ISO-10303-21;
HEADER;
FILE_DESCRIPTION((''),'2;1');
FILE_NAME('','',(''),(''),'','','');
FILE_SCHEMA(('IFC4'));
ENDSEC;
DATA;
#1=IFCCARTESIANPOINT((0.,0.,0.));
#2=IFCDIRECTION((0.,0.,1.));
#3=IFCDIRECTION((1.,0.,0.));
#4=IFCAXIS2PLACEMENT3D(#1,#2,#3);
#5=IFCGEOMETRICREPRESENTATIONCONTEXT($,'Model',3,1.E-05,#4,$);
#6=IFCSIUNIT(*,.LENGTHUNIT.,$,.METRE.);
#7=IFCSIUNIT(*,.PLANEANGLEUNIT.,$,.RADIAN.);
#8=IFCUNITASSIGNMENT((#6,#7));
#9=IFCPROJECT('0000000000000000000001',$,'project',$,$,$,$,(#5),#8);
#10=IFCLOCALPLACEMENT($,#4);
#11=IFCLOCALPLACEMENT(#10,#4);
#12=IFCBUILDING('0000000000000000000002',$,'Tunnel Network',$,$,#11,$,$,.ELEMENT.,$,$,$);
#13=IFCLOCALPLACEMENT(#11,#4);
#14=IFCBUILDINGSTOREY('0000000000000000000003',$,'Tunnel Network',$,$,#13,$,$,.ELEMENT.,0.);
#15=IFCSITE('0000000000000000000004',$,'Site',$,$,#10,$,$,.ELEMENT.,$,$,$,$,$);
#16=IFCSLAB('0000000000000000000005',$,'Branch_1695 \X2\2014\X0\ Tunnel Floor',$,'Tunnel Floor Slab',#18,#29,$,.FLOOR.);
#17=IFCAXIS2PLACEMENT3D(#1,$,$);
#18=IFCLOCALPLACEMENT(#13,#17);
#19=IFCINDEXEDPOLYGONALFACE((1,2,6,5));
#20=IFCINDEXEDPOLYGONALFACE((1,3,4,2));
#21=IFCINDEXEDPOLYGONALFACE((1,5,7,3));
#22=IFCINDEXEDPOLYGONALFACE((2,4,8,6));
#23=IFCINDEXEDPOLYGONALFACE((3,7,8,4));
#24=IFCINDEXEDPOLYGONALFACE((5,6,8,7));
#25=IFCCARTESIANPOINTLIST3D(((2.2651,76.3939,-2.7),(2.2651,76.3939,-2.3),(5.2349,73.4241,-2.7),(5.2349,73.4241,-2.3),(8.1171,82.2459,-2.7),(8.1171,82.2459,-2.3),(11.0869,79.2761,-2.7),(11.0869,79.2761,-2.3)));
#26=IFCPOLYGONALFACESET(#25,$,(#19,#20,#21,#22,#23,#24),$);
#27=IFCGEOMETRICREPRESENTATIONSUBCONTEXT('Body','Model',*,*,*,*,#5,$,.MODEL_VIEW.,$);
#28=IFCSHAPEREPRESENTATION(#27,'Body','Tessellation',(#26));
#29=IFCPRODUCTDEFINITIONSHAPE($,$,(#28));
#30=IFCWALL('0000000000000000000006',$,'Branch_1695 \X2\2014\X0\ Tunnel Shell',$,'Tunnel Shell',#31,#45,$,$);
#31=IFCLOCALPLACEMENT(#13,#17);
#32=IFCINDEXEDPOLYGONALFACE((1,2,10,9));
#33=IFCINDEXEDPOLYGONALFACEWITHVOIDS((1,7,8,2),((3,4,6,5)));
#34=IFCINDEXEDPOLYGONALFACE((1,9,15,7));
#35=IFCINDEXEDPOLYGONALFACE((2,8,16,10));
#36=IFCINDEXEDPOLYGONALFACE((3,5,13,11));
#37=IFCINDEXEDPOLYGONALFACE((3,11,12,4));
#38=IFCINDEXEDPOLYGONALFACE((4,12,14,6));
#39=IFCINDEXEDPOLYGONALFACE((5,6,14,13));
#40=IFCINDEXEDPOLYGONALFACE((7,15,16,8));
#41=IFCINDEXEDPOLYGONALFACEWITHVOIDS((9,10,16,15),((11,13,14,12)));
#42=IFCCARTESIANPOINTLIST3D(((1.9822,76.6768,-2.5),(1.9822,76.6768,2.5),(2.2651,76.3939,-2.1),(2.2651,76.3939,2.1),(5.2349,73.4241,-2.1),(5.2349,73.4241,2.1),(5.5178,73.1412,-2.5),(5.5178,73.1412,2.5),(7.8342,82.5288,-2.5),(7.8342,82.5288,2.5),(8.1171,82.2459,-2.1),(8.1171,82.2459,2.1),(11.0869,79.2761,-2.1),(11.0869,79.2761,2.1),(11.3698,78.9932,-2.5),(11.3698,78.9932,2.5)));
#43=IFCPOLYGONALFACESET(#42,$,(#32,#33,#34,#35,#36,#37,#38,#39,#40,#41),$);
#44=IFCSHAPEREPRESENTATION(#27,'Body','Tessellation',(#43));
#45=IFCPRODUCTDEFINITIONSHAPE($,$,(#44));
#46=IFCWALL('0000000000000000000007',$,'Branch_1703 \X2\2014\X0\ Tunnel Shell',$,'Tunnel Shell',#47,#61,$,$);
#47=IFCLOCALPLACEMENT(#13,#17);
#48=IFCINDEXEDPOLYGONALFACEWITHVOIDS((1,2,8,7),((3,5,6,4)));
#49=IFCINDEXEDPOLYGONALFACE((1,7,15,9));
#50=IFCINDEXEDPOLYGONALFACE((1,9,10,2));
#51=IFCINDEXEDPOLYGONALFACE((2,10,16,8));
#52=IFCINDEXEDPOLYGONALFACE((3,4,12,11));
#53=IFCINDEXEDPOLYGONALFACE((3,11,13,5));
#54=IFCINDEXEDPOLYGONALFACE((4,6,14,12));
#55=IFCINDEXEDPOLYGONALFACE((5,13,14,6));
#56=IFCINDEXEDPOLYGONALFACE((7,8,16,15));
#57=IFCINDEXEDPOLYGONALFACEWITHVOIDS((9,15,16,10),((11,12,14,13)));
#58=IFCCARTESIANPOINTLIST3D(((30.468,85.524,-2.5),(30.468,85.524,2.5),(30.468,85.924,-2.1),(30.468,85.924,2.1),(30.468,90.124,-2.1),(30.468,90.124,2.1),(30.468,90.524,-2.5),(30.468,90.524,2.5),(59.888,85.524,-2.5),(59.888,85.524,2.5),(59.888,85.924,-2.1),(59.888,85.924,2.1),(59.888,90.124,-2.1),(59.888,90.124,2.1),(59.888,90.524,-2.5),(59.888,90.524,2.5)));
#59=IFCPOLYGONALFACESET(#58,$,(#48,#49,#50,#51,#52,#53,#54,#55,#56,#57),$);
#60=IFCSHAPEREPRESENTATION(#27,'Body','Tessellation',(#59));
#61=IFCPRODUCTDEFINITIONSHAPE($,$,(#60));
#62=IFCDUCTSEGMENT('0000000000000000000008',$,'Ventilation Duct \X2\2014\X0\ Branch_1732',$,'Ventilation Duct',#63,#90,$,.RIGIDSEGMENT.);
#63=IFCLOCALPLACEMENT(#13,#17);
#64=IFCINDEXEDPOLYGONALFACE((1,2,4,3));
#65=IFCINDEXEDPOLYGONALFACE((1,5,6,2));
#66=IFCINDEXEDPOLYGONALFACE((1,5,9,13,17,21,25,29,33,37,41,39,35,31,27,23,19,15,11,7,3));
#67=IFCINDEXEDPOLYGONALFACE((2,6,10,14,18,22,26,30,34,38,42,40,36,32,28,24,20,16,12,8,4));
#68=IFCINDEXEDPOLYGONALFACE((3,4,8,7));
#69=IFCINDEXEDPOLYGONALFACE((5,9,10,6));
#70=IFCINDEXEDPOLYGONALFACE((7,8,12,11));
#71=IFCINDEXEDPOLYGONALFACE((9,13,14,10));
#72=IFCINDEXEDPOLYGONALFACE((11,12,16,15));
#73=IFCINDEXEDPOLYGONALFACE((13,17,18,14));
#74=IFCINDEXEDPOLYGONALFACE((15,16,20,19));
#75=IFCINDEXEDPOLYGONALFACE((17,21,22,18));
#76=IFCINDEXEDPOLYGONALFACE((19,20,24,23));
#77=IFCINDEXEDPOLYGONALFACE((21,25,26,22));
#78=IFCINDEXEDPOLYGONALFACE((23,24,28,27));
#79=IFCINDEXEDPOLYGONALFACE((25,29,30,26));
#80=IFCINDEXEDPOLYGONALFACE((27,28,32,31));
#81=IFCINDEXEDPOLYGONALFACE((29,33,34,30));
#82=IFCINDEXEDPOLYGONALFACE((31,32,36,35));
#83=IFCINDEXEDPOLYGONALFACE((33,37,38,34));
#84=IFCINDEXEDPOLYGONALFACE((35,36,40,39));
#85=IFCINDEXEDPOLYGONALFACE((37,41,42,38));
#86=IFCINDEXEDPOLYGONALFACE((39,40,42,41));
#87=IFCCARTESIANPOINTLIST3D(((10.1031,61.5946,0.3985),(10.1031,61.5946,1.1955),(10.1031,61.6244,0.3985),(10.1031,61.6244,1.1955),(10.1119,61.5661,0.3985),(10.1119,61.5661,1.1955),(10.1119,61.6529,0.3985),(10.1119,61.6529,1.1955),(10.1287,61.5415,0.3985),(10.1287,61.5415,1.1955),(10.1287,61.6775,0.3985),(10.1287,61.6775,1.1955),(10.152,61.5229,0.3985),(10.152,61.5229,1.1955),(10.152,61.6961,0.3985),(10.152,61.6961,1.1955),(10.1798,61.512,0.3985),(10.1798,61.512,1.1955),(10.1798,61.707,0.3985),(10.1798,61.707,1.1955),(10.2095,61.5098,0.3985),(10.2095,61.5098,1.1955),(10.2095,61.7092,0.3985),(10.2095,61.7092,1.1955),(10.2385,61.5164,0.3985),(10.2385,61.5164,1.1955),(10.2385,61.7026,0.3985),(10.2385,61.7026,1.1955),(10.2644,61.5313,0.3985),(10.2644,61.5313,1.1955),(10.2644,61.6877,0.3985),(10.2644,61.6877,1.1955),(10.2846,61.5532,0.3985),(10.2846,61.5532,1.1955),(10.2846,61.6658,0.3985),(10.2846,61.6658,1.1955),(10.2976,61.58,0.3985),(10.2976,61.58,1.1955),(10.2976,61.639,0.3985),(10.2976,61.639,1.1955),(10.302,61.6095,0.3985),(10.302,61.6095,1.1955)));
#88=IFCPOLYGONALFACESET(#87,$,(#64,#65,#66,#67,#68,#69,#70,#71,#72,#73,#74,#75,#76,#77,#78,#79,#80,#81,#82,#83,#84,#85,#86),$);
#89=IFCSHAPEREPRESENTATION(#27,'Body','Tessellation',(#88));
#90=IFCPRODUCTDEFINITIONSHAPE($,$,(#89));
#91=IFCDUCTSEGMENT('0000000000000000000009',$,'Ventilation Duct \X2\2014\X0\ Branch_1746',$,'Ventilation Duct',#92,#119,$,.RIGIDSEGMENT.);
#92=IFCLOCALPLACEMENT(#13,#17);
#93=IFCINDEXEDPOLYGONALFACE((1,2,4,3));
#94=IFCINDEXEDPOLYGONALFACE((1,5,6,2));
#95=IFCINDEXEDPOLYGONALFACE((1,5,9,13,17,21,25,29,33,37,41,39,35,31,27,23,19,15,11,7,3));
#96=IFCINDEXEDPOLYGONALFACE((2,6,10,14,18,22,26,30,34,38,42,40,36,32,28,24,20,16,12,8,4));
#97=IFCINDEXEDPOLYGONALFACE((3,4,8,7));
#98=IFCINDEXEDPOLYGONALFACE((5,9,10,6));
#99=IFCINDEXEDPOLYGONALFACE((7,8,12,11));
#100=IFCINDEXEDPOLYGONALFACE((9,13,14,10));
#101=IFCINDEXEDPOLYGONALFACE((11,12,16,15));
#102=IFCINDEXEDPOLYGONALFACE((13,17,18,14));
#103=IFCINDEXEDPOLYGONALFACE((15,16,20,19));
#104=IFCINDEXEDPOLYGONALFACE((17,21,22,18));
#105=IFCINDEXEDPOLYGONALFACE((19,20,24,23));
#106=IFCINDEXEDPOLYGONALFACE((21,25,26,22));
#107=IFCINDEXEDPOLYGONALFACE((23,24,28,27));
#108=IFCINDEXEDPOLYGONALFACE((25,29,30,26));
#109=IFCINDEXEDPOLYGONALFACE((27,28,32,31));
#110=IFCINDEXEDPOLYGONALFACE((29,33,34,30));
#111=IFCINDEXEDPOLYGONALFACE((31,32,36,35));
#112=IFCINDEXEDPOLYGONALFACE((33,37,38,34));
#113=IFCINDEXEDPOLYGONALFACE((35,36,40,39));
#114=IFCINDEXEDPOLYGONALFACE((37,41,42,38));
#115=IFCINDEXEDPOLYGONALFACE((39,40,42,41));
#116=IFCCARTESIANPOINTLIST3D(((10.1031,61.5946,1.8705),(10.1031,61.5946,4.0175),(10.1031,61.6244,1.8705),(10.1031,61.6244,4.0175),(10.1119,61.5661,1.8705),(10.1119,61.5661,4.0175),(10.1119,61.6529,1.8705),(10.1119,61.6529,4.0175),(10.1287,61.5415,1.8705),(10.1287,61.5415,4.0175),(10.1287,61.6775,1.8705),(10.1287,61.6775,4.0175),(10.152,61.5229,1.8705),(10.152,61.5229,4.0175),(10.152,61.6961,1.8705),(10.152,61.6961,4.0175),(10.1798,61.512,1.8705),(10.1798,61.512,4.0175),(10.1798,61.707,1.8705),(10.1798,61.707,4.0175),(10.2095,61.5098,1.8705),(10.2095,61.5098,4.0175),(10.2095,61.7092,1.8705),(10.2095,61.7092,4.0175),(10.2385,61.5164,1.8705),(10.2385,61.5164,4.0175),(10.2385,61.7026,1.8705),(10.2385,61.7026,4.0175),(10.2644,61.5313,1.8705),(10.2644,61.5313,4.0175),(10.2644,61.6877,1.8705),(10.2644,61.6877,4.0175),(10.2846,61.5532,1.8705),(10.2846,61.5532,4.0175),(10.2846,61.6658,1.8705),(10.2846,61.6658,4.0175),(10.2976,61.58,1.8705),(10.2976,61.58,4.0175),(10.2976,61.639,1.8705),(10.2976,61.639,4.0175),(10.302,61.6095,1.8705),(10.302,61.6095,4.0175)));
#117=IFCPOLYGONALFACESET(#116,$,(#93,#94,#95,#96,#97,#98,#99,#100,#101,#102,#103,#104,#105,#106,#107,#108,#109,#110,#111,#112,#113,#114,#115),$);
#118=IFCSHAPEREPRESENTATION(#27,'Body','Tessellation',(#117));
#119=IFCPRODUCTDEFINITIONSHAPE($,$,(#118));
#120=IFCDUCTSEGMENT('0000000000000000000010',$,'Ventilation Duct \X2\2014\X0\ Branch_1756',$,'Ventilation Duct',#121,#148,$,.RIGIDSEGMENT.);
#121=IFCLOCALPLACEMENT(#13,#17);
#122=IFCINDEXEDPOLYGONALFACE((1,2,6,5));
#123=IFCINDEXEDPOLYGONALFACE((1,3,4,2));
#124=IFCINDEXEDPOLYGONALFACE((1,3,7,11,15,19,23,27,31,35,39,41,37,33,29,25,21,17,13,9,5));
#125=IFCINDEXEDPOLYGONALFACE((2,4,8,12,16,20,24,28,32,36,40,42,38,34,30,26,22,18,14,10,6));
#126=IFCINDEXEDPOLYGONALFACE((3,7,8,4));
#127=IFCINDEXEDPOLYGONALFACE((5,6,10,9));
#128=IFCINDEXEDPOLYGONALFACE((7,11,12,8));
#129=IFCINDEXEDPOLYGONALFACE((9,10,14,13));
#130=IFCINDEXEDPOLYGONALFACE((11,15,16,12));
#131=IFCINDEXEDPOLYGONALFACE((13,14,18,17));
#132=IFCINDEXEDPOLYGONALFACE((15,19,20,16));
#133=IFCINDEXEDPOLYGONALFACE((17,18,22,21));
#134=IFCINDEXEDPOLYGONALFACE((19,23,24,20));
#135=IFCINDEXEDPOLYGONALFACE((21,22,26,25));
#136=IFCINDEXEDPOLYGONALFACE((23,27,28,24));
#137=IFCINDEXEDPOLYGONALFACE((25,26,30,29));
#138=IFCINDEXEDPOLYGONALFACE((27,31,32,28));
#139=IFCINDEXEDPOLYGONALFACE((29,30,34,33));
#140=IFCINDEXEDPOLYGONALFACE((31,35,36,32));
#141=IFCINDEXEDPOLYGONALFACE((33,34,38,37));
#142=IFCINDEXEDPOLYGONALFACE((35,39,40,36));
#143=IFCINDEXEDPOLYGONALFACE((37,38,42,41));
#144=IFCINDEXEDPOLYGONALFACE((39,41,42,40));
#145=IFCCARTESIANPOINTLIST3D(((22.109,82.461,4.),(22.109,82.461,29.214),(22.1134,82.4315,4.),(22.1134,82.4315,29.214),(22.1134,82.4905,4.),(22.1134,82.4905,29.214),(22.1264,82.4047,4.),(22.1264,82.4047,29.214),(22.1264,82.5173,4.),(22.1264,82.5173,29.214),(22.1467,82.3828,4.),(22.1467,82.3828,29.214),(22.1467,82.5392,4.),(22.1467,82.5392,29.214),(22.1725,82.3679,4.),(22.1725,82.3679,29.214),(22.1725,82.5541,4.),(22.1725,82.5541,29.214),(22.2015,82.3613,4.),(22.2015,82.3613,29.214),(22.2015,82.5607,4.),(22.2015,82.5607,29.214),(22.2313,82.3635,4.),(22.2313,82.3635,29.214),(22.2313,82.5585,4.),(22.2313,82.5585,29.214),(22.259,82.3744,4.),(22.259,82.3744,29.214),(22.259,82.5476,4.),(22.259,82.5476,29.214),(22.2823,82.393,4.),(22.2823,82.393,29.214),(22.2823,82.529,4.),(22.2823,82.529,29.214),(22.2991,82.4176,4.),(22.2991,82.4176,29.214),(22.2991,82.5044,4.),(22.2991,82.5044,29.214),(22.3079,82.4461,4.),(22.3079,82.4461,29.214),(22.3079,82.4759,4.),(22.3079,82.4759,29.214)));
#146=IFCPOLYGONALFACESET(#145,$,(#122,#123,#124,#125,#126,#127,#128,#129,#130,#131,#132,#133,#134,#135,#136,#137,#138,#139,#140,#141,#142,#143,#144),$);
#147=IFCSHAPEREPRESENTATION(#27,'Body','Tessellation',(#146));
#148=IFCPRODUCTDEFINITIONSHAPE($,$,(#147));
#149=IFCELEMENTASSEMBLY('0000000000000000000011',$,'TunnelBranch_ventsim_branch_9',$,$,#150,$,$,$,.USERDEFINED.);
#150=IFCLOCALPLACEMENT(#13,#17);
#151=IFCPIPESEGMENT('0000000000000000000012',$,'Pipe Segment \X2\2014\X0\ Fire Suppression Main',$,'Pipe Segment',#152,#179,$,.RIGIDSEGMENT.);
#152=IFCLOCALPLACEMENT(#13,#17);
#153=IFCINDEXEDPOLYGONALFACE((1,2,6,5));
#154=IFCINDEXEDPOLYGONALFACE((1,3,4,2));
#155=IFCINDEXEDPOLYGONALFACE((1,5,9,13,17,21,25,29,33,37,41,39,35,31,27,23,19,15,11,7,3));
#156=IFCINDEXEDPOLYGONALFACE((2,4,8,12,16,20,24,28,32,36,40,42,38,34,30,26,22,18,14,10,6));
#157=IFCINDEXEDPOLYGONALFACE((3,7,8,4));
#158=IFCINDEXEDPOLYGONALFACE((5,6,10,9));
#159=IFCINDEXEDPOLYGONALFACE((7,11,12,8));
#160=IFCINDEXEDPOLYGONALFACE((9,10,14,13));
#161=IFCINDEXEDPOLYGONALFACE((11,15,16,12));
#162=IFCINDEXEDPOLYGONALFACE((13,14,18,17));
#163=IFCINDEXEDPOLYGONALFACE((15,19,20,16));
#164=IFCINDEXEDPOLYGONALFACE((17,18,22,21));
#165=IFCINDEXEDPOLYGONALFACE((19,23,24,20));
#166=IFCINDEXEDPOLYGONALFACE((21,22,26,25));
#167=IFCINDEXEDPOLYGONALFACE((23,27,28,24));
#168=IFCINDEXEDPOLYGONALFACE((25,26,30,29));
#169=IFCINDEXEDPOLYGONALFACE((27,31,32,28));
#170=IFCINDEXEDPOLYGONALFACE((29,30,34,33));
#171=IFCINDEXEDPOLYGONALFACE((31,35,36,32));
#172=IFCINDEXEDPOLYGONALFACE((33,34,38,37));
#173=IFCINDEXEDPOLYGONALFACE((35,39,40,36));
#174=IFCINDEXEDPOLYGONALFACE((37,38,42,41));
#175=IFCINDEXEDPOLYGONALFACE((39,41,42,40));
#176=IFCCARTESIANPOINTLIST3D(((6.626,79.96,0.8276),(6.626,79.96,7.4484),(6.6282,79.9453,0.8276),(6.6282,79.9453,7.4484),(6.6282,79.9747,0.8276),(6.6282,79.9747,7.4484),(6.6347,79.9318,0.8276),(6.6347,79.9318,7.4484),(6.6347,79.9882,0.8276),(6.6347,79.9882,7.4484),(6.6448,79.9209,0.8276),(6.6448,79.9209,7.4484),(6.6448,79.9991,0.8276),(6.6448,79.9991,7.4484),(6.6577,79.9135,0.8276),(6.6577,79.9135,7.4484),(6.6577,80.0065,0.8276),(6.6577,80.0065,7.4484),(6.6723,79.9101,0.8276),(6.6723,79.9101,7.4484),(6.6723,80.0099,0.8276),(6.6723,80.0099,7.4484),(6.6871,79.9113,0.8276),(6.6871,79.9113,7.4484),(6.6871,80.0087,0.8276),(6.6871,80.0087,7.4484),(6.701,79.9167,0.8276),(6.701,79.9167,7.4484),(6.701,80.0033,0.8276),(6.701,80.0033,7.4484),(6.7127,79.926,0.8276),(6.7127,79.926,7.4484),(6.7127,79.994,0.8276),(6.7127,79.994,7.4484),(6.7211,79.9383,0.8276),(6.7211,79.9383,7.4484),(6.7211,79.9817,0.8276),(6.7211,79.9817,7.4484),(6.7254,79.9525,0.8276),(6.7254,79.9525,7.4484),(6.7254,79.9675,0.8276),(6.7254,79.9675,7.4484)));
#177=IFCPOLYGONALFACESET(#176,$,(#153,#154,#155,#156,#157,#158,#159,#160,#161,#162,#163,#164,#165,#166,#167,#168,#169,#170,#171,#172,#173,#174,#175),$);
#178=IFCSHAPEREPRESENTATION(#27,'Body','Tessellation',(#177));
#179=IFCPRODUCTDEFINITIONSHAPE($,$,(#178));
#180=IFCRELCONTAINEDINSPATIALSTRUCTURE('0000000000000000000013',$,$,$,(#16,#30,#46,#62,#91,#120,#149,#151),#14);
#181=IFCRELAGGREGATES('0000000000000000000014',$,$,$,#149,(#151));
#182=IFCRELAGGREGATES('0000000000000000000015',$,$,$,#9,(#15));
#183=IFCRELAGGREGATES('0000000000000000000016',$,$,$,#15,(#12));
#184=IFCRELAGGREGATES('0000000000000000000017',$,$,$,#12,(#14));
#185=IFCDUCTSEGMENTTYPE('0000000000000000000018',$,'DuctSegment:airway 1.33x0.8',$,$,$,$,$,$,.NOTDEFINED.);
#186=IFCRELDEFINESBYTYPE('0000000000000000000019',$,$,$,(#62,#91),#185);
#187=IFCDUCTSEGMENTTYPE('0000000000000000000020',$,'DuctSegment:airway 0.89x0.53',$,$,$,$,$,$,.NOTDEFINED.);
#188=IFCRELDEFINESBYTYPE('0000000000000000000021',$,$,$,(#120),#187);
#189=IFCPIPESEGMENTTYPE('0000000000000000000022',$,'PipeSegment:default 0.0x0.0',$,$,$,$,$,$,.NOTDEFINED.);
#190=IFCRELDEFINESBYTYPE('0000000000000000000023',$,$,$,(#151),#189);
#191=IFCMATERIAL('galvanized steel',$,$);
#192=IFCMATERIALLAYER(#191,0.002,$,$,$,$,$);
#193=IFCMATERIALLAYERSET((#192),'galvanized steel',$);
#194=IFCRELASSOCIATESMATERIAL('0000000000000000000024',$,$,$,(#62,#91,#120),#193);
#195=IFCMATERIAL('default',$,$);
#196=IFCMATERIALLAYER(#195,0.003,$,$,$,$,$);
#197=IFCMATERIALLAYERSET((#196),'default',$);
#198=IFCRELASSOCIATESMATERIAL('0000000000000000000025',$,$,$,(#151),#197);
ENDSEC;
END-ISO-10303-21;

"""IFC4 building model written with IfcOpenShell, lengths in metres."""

from ifc_helpers import new_model, entity, si_unit, frame, origin_with_axes, origin_2d_with_axis, place, context, subcontext, project, spatial, rectangle, hollow_rectangle, circle, extrude, material, layer, layer_set, layer_usage, type_object, element, aggregate, save


model = new_model("IFC4")

# Units and contexts
model_context = context("Model", 3, precision=1e-05, world=origin_with_axes())
body_context = subcontext(model_context, "Body", "Model", "MODEL_VIEW")
ifc_project = project(units=[si_unit("LENGTHUNIT", "METRE"), si_unit("PLANEANGLEUNIT", "RADIAN")], contexts=[model_context])

# Site, building, storey
site_placement = place(None, origin_with_axes())
site = spatial("IfcSite", under=ifc_project, at=site_placement, Name="Site", CompositionType="ELEMENT")
building_placement = place(site_placement, origin_with_axes())
building = spatial("IfcBuilding", under=site, at=building_placement, Name="Tunnel Network", CompositionType="ELEMENT")
storey_placement = place(building_placement, origin_with_axes())
storey = spatial("IfcBuildingStorey", under=building, at=storey_placement, Name="Tunnel Network", CompositionType="ELEMENT", Elevation=0.0)

# Slab
placement = place(storey_placement, frame((9.602, 80.761, 0.0), z_axis=(0.0, 0.0, 1.0), x_axis=(-0.707107, -0.707106, 0.0)))
element("IfcSlab", 1, at=placement, inside=storey, Name="Branch_1695 — Tunnel Floor", ObjectType="Tunnel Floor Slab", PredefinedType="FLOOR", context=body_context, shape_type="SweptSolid", body=[
    extrude(rectangle(XDim=0.4, YDim=4.2, at=origin_2d_with_axis()), frame((0.0, 0.0, -2.5), z_axis=(1.0, 0.0, 0.0), x_axis=(0.0, 0.0, 1.0)), (0.0, 0.0, 1.0), 8.276),
])

# Walls
element("IfcWall", 2, at=placement, inside=storey, Name="Branch_1695 — Tunnel Shell", ObjectType="Tunnel Shell", context=body_context, shape_type="SweptSolid", body=[
    extrude(hollow_rectangle(XDim=5.0, YDim=5.0, WallThickness=0.4, at=origin_2d_with_axis()), frame((0.0, 0.0, 0.0), z_axis=(1.0, 0.0, 0.0), x_axis=(0.0, 0.0, 1.0)), (0.0, 0.0, 1.0), 8.276),
])
wall_1_placement = place(storey_placement, frame((30.468, 88.024, 0.0), z_axis=(0.0, 0.0, 1.0), x_axis=(1.0, 0.0, 0.0)))
element("IfcWall", 3, at=wall_1_placement, inside=storey, Name="Branch_1703 — Tunnel Shell", ObjectType="Tunnel Shell", context=body_context, shape_type="SweptSolid", body=[
    extrude(hollow_rectangle(XDim=5.0, YDim=5.0, WallThickness=0.4, at=origin_2d_with_axis()), frame((0.0, 0.0, 0.0), z_axis=(1.0, 0.0, 0.0), x_axis=(0.0, 0.0, 1.0)), (0.0, 0.0, 1.0), 29.42),
])

# Duct segments
ifc_material_1 = material(Name="galvanized steel")
ifc_layer_1 = layer(ifc_material_1, 0.002)
ifc_layer_set_1 = layer_set([ifc_layer_1], Name="galvanized steel")
ifc_layer_usage_1 = layer_usage(ifc_layer_set_1, "AXIS2", "POSITIVE", 0.0)
duct_segment_type_1 = type_object("IfcDuctSegmentType", Name="DuctSegment:airway 1.33x0.8")
duct_segment_1_placement = place(storey_placement, frame((10.202, 61.6095, 0.3985), z_axis=(0.0, 0.0, 1.0), x_axis=(1.0, 0.0, 0.0)))
element("IfcDuctSegment", 4, at=duct_segment_1_placement, inside=storey, type_object=duct_segment_type_1, material=ifc_layer_usage_1, Name="Ventilation Duct — Branch_1732", ObjectType="Ventilation Duct", PredefinedType="RIGIDSEGMENT", context=body_context, shape_type="AdvancedSweptSolid", body=[
    entity("IfcSweptDiskSolid", entity("IfcPolyline", [entity("IfcCartesianPoint", [0.0, 0.0, 0.0]), entity("IfcCartesianPoint", [0.0, 0.0, 0.797])]), 0.1),
])
ifc_layer_usage_2 = layer_usage(ifc_layer_set_1, "AXIS2", "POSITIVE", 0.0)
duct_segment_2_placement = place(storey_placement, frame((10.202, 61.6095, 1.8705), z_axis=(0.0, 0.0, 1.0), x_axis=(1.0, 0.0, 0.0)))
element("IfcDuctSegment", 5, at=duct_segment_2_placement, inside=storey, type_object=duct_segment_type_1, material=ifc_layer_usage_2, Name="Ventilation Duct — Branch_1746", ObjectType="Ventilation Duct", PredefinedType="RIGIDSEGMENT", context=body_context, shape_type="AdvancedSweptSolid", body=[
    entity("IfcSweptDiskSolid", entity("IfcPolyline", [entity("IfcCartesianPoint", [0.0, 0.0, 0.0]), entity("IfcCartesianPoint", [0.0, 0.0, 2.147])]), 0.1),
])
ifc_layer_usage_3 = layer_usage(ifc_layer_set_1, "AXIS2", "POSITIVE", 0.0)
duct_segment_type_2 = type_object("IfcDuctSegmentType", Name="DuctSegment:airway 0.89x0.53")
duct_segment_3_placement = place(storey_placement, frame((22.209, 82.461, 4.0), z_axis=(0.0, 0.0, 1.0), x_axis=(-1.0, 0.0, 0.0)))
element("IfcDuctSegment", 6, at=duct_segment_3_placement, inside=storey, type_object=duct_segment_type_2, material=ifc_layer_usage_3, Name="Ventilation Duct — Branch_1756", ObjectType="Ventilation Duct", PredefinedType="RIGIDSEGMENT", context=body_context, shape_type="AdvancedSweptSolid", body=[
    entity("IfcSweptDiskSolid", entity("IfcPolyline", [entity("IfcCartesianPoint", [0.0, 0.0, 0.0]), entity("IfcCartesianPoint", [0.0, 0.0, 25.214])]), 0.1),
])

# Element assembly, pipe segment
assembly_1_placement = place(storey_placement, frame((6.676, 79.96, 0.8276), z_axis=(0.0, 0.0, 1.0), x_axis=(-1.0, 0.0, 0.0)))
assembly_1 = element("IfcElementAssembly", 7, at=assembly_1_placement, inside=storey, Name="TunnelBranch_ventsim_branch_9", PredefinedType="USERDEFINED")
ifc_material_2 = material(Name="default")
ifc_layer_2 = layer(ifc_material_2, 0.003)
ifc_layer_set_2 = layer_set([ifc_layer_2], Name="default")
ifc_layer_usage_4 = layer_usage(ifc_layer_set_2, "AXIS2", "POSITIVE", 0.0)
pipe_segment_type = type_object("IfcPipeSegmentType", Name="PipeSegment:default 0.0x0.0")
pipe_segment_1_placement = place(storey_placement, frame((6.676, 79.96, 0.8276), z_axis=(0.0, 0.0, 1.0), x_axis=(-1.0, 0.0, 0.0)))
pipe_segment_1 = element("IfcPipeSegment", 8, at=pipe_segment_1_placement, inside=storey, type_object=pipe_segment_type, material=ifc_layer_usage_4, Name="Pipe Segment — Fire Suppression Main", ObjectType="Pipe Segment", PredefinedType="RIGIDSEGMENT", context=body_context, shape_type="SweptSolid", body=[
    extrude(circle(Radius=0.05, at=origin_2d_with_axis()), origin_with_axes(), (0.0, 0.0, 1.0), 6.6208),
])

aggregate(assembly_1, [pipe_segment_1])

save(model, "model.ifc")
